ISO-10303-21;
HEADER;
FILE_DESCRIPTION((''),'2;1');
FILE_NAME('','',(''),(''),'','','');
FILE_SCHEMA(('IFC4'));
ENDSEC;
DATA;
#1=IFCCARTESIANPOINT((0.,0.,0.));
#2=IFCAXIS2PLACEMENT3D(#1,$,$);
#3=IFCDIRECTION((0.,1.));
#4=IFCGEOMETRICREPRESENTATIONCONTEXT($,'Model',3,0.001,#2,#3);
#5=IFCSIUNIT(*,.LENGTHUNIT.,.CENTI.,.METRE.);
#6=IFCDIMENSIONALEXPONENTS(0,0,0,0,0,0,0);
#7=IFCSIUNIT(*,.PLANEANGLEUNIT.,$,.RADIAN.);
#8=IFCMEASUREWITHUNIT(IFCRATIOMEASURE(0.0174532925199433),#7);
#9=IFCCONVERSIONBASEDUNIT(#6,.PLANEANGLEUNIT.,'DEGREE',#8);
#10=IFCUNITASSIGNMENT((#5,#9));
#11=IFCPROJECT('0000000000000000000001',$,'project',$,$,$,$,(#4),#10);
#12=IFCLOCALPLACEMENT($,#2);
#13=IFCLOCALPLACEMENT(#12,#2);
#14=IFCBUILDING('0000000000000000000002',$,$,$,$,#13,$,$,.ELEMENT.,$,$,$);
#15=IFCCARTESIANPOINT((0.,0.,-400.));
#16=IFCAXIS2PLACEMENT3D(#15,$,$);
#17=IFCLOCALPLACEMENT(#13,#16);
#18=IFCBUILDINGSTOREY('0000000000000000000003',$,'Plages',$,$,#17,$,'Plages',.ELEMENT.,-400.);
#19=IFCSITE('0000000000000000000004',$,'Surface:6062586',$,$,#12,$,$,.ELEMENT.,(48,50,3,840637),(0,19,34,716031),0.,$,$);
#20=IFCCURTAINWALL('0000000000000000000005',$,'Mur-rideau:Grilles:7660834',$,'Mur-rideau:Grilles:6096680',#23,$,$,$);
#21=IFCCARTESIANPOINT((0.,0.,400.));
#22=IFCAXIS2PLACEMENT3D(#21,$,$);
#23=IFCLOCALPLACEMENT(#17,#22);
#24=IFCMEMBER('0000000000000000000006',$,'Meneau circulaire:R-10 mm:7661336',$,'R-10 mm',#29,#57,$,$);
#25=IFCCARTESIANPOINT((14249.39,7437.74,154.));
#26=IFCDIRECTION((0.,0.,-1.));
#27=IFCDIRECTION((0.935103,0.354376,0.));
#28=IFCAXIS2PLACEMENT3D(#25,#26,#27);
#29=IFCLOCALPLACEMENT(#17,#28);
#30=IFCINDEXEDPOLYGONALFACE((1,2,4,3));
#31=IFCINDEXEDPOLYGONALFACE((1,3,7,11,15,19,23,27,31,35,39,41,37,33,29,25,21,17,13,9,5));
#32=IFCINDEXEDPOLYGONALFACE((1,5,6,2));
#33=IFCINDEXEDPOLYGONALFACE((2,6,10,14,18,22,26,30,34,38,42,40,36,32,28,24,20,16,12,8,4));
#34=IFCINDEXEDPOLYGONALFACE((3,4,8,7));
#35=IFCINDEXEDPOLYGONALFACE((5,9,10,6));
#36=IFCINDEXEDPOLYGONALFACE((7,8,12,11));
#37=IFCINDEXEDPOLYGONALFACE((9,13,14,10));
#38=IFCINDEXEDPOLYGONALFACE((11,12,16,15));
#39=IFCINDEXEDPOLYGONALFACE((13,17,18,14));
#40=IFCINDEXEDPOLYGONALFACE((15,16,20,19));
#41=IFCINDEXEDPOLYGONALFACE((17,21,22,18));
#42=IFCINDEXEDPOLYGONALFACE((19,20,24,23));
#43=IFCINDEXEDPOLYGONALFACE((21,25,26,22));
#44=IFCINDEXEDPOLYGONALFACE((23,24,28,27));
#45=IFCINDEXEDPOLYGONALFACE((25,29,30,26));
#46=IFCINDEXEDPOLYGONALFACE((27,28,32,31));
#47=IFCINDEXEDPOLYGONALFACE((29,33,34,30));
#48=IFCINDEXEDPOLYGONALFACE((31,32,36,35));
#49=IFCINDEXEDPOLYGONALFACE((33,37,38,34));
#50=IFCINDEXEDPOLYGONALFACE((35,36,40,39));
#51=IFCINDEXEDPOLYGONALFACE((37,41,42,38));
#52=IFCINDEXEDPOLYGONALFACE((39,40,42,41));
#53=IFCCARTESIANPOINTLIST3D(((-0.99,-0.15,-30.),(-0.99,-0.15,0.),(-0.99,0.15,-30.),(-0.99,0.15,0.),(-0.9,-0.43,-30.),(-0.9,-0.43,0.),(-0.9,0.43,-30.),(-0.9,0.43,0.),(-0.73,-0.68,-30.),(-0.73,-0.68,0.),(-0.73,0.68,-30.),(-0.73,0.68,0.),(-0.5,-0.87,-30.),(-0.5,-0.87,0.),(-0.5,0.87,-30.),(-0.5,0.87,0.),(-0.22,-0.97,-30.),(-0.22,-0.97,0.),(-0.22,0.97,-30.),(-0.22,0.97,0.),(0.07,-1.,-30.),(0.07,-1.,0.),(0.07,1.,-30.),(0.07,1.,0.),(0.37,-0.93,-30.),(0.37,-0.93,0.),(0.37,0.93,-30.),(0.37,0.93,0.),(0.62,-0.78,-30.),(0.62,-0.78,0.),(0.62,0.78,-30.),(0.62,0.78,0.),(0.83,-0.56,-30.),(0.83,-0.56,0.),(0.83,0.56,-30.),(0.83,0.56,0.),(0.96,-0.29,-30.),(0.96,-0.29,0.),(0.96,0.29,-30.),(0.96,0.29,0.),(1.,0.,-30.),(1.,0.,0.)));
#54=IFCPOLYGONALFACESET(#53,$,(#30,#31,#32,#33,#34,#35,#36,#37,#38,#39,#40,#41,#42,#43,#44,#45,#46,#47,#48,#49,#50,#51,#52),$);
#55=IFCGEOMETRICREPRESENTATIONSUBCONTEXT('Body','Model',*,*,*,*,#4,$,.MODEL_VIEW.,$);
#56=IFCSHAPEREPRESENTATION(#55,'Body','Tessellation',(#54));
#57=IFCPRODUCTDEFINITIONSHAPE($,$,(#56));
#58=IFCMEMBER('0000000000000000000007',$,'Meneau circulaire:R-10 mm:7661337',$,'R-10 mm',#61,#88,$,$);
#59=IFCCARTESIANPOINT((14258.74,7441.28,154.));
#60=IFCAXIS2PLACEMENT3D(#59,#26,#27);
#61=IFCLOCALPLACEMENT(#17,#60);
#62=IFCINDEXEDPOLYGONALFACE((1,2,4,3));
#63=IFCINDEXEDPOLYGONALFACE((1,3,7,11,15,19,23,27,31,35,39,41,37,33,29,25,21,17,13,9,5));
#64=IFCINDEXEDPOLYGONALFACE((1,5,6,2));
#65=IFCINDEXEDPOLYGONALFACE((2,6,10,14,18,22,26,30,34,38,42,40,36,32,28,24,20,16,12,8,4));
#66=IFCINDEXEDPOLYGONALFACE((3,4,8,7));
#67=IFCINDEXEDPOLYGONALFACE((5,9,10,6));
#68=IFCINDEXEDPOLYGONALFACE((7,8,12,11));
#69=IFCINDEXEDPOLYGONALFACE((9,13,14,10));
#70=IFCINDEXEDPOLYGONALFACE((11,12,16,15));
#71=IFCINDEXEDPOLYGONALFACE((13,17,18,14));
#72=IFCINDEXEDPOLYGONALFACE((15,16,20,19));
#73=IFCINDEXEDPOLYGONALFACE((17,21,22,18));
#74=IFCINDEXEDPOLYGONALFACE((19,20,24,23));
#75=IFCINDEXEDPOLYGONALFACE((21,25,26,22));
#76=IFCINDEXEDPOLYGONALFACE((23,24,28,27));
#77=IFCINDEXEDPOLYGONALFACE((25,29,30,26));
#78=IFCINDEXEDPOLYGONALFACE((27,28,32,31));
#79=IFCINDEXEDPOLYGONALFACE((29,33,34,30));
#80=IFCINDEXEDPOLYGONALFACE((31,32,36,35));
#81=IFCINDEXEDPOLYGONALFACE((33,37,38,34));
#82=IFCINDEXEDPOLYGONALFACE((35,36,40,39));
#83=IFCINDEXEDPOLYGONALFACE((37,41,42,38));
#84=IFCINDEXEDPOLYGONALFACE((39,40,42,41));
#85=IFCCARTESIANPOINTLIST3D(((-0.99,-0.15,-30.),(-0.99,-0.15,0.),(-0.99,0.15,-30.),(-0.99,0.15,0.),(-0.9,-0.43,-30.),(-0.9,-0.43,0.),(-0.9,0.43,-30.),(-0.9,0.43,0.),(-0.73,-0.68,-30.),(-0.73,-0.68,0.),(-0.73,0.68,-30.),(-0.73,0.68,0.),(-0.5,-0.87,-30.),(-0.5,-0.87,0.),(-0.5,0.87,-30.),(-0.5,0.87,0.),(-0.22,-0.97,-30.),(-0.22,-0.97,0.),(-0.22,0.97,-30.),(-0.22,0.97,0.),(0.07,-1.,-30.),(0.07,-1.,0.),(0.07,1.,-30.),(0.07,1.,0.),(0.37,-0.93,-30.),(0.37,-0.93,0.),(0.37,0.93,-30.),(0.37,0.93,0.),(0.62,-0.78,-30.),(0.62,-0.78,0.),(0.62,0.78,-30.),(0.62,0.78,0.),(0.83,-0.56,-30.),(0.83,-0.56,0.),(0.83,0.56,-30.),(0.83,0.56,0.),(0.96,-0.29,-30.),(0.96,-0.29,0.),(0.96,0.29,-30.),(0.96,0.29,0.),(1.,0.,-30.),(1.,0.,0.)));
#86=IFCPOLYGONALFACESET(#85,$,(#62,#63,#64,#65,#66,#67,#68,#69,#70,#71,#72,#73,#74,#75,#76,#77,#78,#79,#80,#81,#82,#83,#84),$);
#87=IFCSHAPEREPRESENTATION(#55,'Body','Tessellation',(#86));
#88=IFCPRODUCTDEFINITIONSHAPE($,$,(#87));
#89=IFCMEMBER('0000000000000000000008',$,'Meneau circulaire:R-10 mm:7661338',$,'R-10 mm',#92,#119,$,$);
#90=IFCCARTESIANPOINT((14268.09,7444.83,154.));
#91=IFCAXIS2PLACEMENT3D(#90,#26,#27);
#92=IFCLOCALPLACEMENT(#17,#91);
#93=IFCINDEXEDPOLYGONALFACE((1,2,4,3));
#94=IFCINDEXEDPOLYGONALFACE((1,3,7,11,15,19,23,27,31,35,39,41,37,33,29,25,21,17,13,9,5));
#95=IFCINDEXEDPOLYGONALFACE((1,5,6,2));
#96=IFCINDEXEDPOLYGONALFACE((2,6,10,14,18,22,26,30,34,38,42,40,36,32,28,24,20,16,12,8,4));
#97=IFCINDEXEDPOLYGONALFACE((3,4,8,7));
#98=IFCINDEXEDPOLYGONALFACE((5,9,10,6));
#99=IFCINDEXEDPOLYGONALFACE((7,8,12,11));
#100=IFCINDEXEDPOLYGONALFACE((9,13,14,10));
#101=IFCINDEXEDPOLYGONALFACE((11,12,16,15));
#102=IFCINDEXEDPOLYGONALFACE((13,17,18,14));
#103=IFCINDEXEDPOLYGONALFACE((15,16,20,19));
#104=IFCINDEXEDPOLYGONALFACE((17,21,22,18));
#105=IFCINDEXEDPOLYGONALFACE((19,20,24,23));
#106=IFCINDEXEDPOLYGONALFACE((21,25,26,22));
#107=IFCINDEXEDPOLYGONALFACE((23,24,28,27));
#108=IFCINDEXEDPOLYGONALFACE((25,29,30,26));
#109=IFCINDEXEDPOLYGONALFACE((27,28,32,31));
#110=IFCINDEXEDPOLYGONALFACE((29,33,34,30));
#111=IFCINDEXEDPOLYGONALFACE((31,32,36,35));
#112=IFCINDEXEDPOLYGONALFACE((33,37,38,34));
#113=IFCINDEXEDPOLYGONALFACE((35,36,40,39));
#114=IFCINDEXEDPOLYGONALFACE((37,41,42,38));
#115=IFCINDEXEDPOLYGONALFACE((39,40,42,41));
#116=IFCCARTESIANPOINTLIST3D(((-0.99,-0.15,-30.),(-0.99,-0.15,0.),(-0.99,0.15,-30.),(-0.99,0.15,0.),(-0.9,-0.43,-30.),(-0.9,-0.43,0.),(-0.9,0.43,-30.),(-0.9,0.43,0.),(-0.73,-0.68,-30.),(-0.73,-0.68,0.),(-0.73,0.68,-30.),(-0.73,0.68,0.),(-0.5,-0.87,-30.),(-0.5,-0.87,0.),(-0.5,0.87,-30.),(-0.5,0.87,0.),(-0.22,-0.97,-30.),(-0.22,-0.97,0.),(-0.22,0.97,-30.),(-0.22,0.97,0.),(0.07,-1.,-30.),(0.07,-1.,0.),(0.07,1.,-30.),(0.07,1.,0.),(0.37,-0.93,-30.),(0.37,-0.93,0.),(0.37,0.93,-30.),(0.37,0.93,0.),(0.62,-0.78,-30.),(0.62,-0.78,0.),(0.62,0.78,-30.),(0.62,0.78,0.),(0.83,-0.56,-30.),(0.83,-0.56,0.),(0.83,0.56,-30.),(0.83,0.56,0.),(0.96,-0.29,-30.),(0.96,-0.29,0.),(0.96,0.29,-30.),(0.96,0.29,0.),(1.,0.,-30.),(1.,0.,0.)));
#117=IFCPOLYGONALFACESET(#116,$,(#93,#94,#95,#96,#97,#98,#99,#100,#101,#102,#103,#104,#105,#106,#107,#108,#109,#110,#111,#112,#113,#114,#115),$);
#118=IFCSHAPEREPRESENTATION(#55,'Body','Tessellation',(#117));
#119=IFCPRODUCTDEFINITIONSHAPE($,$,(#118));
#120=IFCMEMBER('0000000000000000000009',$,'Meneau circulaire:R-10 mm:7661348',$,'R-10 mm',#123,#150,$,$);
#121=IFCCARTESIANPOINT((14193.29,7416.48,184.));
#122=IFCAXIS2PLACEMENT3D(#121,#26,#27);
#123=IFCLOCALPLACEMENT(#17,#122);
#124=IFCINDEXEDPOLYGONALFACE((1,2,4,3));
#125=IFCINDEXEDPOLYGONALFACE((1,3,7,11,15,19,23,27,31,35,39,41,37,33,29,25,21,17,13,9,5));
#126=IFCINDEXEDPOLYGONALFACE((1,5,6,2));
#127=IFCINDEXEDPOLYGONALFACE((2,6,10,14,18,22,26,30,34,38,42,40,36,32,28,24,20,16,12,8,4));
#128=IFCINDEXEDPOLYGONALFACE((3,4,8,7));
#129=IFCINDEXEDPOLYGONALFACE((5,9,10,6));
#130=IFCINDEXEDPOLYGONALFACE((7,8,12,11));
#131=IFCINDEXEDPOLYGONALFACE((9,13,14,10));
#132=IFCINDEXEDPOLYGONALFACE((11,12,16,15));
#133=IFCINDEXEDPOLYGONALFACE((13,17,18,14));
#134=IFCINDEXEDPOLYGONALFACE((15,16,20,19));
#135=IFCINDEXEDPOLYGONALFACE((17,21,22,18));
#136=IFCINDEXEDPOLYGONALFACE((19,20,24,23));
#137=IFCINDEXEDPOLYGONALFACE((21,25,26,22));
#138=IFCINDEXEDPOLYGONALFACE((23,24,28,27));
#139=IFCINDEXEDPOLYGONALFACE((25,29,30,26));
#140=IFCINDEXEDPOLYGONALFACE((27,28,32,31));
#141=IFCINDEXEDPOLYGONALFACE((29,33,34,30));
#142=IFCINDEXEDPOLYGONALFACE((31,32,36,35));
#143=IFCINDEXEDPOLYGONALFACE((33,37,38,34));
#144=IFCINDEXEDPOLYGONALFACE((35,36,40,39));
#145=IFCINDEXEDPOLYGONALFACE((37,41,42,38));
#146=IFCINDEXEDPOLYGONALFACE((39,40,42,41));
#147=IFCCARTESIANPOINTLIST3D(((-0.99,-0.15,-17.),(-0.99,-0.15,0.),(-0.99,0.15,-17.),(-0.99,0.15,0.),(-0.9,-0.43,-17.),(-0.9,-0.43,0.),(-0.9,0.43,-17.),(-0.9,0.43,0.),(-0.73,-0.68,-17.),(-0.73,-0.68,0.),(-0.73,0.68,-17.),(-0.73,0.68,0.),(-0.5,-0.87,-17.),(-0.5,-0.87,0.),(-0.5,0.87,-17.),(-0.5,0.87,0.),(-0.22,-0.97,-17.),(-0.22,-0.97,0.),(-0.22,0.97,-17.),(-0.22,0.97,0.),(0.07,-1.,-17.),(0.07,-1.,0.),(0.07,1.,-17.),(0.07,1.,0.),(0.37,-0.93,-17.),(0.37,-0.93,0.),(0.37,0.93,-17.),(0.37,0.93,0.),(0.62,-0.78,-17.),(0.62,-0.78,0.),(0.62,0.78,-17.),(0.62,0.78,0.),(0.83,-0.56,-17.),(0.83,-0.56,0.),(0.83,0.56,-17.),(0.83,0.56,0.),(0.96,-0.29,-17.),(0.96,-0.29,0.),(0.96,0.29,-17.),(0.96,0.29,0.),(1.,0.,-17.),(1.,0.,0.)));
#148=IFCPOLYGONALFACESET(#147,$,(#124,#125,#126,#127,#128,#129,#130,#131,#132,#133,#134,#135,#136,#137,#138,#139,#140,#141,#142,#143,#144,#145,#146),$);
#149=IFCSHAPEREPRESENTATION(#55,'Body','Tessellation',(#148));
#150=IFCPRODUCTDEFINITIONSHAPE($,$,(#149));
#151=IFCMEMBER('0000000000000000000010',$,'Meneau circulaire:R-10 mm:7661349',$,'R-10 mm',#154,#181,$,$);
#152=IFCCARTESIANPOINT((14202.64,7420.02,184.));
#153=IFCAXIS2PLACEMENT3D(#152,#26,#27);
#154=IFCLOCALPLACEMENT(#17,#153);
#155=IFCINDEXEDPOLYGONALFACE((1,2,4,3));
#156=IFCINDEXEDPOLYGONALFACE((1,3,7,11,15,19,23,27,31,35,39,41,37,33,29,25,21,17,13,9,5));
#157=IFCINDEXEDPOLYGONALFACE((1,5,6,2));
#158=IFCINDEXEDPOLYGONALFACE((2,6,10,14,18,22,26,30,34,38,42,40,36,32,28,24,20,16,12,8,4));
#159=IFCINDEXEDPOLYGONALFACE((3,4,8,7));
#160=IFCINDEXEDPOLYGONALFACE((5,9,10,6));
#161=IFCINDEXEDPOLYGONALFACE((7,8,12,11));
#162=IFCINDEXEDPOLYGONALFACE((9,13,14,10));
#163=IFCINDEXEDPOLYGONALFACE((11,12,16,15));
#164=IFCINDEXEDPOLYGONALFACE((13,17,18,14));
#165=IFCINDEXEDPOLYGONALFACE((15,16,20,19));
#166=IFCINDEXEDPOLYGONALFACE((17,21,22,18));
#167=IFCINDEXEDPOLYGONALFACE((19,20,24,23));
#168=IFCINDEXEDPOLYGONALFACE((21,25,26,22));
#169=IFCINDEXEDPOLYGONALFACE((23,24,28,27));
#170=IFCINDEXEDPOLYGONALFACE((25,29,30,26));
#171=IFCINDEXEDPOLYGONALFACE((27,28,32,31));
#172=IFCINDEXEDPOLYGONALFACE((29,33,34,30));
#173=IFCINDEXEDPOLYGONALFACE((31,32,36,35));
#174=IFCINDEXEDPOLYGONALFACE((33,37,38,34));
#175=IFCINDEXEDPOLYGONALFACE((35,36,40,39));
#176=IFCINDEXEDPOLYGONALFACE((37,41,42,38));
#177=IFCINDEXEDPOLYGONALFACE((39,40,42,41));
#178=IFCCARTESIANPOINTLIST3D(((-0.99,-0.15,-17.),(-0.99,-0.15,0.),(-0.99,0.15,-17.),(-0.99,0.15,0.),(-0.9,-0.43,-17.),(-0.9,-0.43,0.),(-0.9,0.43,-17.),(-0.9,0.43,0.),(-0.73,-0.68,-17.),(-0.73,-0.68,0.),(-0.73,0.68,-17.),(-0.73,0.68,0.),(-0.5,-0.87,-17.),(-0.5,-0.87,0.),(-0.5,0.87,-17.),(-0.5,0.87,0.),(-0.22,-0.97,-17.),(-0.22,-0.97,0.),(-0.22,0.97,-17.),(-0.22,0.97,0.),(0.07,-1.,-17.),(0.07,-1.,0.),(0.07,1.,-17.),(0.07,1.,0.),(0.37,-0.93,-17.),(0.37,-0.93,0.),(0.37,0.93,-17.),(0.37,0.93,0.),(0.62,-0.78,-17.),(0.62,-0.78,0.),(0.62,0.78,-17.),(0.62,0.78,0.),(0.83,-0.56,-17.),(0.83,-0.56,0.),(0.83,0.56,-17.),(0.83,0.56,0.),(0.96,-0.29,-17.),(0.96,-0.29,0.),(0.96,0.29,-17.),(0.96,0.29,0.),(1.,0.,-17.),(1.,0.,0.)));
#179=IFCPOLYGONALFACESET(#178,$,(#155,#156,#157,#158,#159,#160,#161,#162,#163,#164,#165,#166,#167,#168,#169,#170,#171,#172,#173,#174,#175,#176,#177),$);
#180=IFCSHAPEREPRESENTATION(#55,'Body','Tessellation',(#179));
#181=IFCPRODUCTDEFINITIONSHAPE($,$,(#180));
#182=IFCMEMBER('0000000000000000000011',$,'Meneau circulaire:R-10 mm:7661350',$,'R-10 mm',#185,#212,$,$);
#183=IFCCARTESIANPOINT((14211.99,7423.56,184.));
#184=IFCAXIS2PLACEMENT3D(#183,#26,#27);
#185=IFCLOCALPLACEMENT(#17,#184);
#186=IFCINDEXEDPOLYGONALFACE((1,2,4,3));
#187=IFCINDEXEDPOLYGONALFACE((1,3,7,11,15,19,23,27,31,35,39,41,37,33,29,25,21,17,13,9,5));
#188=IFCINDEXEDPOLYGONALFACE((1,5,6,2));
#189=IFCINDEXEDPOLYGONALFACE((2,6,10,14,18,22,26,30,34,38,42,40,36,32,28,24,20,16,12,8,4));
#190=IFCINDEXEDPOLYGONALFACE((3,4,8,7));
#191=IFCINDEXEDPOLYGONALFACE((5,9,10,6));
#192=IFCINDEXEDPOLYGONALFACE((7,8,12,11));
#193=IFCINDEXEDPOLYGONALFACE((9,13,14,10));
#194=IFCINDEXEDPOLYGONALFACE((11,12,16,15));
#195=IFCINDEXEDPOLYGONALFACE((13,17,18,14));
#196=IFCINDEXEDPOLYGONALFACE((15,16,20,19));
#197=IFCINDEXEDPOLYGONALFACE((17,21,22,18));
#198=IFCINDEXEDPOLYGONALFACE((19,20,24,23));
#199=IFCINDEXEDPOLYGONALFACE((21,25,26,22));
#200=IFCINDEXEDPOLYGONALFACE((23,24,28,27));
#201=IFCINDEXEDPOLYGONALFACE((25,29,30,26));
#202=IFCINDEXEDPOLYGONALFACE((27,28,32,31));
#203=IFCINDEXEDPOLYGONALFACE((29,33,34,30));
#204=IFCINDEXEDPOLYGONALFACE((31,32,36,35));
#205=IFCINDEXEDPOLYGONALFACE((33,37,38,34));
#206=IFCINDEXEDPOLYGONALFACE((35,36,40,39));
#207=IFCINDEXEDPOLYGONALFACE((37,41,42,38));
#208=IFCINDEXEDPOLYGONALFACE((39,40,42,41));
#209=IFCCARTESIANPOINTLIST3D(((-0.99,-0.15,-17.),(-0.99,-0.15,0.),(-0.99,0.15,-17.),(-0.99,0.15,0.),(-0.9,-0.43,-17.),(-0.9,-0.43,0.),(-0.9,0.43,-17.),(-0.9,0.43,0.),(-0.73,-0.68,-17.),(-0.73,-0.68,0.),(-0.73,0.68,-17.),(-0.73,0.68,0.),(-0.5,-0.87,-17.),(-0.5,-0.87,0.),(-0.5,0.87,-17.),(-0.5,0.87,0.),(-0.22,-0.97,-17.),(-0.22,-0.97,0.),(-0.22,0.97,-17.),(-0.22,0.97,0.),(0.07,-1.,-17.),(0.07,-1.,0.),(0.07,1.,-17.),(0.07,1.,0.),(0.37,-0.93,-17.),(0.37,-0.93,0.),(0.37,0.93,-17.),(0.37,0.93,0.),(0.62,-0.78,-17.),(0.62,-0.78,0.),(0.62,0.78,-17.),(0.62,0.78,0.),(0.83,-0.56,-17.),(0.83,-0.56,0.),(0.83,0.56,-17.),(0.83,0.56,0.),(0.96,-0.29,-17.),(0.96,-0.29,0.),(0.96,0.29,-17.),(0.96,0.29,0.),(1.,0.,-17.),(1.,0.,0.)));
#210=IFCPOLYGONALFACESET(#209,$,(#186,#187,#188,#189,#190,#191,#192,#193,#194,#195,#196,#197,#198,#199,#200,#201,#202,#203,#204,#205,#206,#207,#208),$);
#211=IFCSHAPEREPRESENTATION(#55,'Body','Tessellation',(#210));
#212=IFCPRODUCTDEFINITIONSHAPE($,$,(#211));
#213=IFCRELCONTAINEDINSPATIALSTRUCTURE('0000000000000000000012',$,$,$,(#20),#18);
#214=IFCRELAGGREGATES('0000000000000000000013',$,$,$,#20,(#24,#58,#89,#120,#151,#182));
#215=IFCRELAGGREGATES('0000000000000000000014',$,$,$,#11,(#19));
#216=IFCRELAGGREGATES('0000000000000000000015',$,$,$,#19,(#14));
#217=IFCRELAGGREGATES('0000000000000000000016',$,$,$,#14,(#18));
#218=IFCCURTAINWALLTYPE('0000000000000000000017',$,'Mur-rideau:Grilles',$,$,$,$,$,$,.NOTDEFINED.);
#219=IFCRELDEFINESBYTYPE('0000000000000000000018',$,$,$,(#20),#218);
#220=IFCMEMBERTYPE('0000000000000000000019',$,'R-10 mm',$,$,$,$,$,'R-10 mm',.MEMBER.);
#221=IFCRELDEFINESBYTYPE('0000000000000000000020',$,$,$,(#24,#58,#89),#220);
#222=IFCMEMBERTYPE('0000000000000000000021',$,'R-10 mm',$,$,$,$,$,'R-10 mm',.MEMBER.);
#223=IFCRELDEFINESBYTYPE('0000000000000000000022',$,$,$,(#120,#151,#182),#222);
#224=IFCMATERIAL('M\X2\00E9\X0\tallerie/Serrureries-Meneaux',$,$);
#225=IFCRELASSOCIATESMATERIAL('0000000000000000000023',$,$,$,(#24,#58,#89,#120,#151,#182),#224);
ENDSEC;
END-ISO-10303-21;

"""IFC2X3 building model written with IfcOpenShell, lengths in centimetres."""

from ifc_helpers import new_model, entity, si_unit, converted_unit, direction, frame, frame_2d, origin, place, context, subcontext, project, spatial, circle, extrude, source, transform, mapped, material, type_object, type_shapes, element, aggregate, save


model = new_model("IFC2X3")

# Units and contexts
model_context = context("Model", 3, precision=0.001, world=origin(), true_north=direction((0.0, 1.0)))
body_context = subcontext(model_context, "Body", "Model", "MODEL_VIEW")
ifc_project = project(units=[si_unit("LENGTHUNIT", "METRE", prefix="CENTI"), converted_unit("PLANEANGLEUNIT", "DEGREE", entity("IfcRatioMeasure", 0.0174532925199433), si_unit("PLANEANGLEUNIT", "RADIAN"), dimensions=[0, 0, 0, 0, 0, 0, 0])], contexts=[model_context])

# Site, building, storey
site_placement = place(None, origin())
site = spatial("IfcSite", under=ifc_project, at=site_placement, Name="Surface:6062586", CompositionType="ELEMENT", RefLatitude=(48, 50, 3, 840637), RefLongitude=(0, 19, 34, 716031), RefElevation=0.0)
building_placement = place(site_placement, origin())
building = spatial("IfcBuilding", under=site, at=building_placement, CompositionType="ELEMENT")
storey_placement = place(building_placement, frame((0.0, 0.0, -400.0)))
storey = spatial("IfcBuildingStorey", under=building, at=storey_placement, Name="Plages", LongName="Plages", CompositionType="ELEMENT", Elevation=-400.0)

# Curtain wall, members
curtain_wall_type = type_object("IfcCurtainWallType", Name="Mur-rideau:Grilles", PredefinedType="NOTDEFINED")
curtain_wall_placement = place(storey_placement, frame((0.0, 0.0, 400.0)))
curtain_wall = element("IfcCurtainWall", 1, at=curtain_wall_placement, inside=storey, type_object=curtain_wall_type, Name="Mur-rideau:Grilles:7660834", ObjectType="Mur-rideau:Grilles:6096680")
ifc_material = material(Name="Métallerie/Serrureries-Meneaux")
member_type_1 = type_object("IfcMemberType", Name="R-10 mm", ElementType="R-10 mm", PredefinedType="MEMBER")
shared_shape_1 = source(origin(), body_context, "Body", "SweptSolid", [
    extrude(circle(Radius=1.0, at=frame_2d((0.0, 0.0), x_axis=(1.0, 0.0))), frame((0.0, 0.0, -30.0)), (0.0, 0.0, 1.0), 30.0),
])
type_shapes(member_type_1, [shared_shape_1])
member_1_placement = place(storey_placement, frame((14249.39, 7437.74, 154.0), z_axis=(0.0, 0.0, -1.0), x_axis=(0.935103, 0.354376, 0.0)))
member_1 = element("IfcMember", 2, at=member_1_placement, type_object=member_type_1, material=ifc_material, Name="Meneau circulaire:R-10 mm:7661336", ObjectType="R-10 mm", context=body_context, shape_type="MappedRepresentation", body=[
    mapped(shared_shape_1, transform((0.0, 0.0, 0.0), scale=1.0)),
])
member_2_placement = place(storey_placement, frame((14258.74, 7441.28, 154.0), z_axis=(0.0, 0.0, -1.0), x_axis=(0.935103, 0.354376, 0.0)))
member_2 = element("IfcMember", 3, at=member_2_placement, type_object=member_type_1, material=ifc_material, Name="Meneau circulaire:R-10 mm:7661337", ObjectType="R-10 mm", context=body_context, shape_type="MappedRepresentation", body=[
    mapped(shared_shape_1, transform((0.0, 0.0, 0.0), scale=1.0)),
])
member_3_placement = place(storey_placement, frame((14268.09, 7444.83, 154.0), z_axis=(0.0, 0.0, -1.0), x_axis=(0.935103, 0.354376, 0.0)))
member_3 = element("IfcMember", 4, at=member_3_placement, type_object=member_type_1, material=ifc_material, Name="Meneau circulaire:R-10 mm:7661338", ObjectType="R-10 mm", context=body_context, shape_type="MappedRepresentation", body=[
    mapped(shared_shape_1, transform((0.0, 0.0, 0.0), scale=1.0)),
])
member_type_2 = type_object("IfcMemberType", Name="R-10 mm", ElementType="R-10 mm", PredefinedType="MEMBER")
shared_shape_2 = source(origin(), body_context, "Body", "SweptSolid", [
    extrude(circle(Radius=1.0, at=frame_2d((0.0, 0.0), x_axis=(1.0, 0.0))), frame((0.0, 0.0, -17.0)), (0.0, 0.0, 1.0), 17.0),
])
type_shapes(member_type_2, [shared_shape_2])
member_4_placement = place(storey_placement, frame((14193.29, 7416.48, 184.0), z_axis=(0.0, 0.0, -1.0), x_axis=(0.935103, 0.354376, 0.0)))
member_4 = element("IfcMember", 5, at=member_4_placement, type_object=member_type_2, material=ifc_material, Name="Meneau circulaire:R-10 mm:7661348", ObjectType="R-10 mm", context=body_context, shape_type="MappedRepresentation", body=[
    mapped(shared_shape_2, transform((0.0, 0.0, 0.0), scale=1.0)),
])
member_5_placement = place(storey_placement, frame((14202.64, 7420.02, 184.0), z_axis=(0.0, 0.0, -1.0), x_axis=(0.935103, 0.354376, 0.0)))
member_5 = element("IfcMember", 6, at=member_5_placement, type_object=member_type_2, material=ifc_material, Name="Meneau circulaire:R-10 mm:7661349", ObjectType="R-10 mm", context=body_context, shape_type="MappedRepresentation", body=[
    mapped(shared_shape_2, transform((0.0, 0.0, 0.0), scale=1.0)),
])
member_6_placement = place(storey_placement, frame((14211.99, 7423.56, 184.0), z_axis=(0.0, 0.0, -1.0), x_axis=(0.935103, 0.354376, 0.0)))
member_6 = element("IfcMember", 7, at=member_6_placement, type_object=member_type_2, material=ifc_material, Name="Meneau circulaire:R-10 mm:7661350", ObjectType="R-10 mm", context=body_context, shape_type="MappedRepresentation", body=[
    mapped(shared_shape_2, transform((0.0, 0.0, 0.0), scale=1.0)),
])
aggregate(curtain_wall, [member_1, member_2, member_3, member_4, member_5, member_6])

save(model, "model.ifc")
